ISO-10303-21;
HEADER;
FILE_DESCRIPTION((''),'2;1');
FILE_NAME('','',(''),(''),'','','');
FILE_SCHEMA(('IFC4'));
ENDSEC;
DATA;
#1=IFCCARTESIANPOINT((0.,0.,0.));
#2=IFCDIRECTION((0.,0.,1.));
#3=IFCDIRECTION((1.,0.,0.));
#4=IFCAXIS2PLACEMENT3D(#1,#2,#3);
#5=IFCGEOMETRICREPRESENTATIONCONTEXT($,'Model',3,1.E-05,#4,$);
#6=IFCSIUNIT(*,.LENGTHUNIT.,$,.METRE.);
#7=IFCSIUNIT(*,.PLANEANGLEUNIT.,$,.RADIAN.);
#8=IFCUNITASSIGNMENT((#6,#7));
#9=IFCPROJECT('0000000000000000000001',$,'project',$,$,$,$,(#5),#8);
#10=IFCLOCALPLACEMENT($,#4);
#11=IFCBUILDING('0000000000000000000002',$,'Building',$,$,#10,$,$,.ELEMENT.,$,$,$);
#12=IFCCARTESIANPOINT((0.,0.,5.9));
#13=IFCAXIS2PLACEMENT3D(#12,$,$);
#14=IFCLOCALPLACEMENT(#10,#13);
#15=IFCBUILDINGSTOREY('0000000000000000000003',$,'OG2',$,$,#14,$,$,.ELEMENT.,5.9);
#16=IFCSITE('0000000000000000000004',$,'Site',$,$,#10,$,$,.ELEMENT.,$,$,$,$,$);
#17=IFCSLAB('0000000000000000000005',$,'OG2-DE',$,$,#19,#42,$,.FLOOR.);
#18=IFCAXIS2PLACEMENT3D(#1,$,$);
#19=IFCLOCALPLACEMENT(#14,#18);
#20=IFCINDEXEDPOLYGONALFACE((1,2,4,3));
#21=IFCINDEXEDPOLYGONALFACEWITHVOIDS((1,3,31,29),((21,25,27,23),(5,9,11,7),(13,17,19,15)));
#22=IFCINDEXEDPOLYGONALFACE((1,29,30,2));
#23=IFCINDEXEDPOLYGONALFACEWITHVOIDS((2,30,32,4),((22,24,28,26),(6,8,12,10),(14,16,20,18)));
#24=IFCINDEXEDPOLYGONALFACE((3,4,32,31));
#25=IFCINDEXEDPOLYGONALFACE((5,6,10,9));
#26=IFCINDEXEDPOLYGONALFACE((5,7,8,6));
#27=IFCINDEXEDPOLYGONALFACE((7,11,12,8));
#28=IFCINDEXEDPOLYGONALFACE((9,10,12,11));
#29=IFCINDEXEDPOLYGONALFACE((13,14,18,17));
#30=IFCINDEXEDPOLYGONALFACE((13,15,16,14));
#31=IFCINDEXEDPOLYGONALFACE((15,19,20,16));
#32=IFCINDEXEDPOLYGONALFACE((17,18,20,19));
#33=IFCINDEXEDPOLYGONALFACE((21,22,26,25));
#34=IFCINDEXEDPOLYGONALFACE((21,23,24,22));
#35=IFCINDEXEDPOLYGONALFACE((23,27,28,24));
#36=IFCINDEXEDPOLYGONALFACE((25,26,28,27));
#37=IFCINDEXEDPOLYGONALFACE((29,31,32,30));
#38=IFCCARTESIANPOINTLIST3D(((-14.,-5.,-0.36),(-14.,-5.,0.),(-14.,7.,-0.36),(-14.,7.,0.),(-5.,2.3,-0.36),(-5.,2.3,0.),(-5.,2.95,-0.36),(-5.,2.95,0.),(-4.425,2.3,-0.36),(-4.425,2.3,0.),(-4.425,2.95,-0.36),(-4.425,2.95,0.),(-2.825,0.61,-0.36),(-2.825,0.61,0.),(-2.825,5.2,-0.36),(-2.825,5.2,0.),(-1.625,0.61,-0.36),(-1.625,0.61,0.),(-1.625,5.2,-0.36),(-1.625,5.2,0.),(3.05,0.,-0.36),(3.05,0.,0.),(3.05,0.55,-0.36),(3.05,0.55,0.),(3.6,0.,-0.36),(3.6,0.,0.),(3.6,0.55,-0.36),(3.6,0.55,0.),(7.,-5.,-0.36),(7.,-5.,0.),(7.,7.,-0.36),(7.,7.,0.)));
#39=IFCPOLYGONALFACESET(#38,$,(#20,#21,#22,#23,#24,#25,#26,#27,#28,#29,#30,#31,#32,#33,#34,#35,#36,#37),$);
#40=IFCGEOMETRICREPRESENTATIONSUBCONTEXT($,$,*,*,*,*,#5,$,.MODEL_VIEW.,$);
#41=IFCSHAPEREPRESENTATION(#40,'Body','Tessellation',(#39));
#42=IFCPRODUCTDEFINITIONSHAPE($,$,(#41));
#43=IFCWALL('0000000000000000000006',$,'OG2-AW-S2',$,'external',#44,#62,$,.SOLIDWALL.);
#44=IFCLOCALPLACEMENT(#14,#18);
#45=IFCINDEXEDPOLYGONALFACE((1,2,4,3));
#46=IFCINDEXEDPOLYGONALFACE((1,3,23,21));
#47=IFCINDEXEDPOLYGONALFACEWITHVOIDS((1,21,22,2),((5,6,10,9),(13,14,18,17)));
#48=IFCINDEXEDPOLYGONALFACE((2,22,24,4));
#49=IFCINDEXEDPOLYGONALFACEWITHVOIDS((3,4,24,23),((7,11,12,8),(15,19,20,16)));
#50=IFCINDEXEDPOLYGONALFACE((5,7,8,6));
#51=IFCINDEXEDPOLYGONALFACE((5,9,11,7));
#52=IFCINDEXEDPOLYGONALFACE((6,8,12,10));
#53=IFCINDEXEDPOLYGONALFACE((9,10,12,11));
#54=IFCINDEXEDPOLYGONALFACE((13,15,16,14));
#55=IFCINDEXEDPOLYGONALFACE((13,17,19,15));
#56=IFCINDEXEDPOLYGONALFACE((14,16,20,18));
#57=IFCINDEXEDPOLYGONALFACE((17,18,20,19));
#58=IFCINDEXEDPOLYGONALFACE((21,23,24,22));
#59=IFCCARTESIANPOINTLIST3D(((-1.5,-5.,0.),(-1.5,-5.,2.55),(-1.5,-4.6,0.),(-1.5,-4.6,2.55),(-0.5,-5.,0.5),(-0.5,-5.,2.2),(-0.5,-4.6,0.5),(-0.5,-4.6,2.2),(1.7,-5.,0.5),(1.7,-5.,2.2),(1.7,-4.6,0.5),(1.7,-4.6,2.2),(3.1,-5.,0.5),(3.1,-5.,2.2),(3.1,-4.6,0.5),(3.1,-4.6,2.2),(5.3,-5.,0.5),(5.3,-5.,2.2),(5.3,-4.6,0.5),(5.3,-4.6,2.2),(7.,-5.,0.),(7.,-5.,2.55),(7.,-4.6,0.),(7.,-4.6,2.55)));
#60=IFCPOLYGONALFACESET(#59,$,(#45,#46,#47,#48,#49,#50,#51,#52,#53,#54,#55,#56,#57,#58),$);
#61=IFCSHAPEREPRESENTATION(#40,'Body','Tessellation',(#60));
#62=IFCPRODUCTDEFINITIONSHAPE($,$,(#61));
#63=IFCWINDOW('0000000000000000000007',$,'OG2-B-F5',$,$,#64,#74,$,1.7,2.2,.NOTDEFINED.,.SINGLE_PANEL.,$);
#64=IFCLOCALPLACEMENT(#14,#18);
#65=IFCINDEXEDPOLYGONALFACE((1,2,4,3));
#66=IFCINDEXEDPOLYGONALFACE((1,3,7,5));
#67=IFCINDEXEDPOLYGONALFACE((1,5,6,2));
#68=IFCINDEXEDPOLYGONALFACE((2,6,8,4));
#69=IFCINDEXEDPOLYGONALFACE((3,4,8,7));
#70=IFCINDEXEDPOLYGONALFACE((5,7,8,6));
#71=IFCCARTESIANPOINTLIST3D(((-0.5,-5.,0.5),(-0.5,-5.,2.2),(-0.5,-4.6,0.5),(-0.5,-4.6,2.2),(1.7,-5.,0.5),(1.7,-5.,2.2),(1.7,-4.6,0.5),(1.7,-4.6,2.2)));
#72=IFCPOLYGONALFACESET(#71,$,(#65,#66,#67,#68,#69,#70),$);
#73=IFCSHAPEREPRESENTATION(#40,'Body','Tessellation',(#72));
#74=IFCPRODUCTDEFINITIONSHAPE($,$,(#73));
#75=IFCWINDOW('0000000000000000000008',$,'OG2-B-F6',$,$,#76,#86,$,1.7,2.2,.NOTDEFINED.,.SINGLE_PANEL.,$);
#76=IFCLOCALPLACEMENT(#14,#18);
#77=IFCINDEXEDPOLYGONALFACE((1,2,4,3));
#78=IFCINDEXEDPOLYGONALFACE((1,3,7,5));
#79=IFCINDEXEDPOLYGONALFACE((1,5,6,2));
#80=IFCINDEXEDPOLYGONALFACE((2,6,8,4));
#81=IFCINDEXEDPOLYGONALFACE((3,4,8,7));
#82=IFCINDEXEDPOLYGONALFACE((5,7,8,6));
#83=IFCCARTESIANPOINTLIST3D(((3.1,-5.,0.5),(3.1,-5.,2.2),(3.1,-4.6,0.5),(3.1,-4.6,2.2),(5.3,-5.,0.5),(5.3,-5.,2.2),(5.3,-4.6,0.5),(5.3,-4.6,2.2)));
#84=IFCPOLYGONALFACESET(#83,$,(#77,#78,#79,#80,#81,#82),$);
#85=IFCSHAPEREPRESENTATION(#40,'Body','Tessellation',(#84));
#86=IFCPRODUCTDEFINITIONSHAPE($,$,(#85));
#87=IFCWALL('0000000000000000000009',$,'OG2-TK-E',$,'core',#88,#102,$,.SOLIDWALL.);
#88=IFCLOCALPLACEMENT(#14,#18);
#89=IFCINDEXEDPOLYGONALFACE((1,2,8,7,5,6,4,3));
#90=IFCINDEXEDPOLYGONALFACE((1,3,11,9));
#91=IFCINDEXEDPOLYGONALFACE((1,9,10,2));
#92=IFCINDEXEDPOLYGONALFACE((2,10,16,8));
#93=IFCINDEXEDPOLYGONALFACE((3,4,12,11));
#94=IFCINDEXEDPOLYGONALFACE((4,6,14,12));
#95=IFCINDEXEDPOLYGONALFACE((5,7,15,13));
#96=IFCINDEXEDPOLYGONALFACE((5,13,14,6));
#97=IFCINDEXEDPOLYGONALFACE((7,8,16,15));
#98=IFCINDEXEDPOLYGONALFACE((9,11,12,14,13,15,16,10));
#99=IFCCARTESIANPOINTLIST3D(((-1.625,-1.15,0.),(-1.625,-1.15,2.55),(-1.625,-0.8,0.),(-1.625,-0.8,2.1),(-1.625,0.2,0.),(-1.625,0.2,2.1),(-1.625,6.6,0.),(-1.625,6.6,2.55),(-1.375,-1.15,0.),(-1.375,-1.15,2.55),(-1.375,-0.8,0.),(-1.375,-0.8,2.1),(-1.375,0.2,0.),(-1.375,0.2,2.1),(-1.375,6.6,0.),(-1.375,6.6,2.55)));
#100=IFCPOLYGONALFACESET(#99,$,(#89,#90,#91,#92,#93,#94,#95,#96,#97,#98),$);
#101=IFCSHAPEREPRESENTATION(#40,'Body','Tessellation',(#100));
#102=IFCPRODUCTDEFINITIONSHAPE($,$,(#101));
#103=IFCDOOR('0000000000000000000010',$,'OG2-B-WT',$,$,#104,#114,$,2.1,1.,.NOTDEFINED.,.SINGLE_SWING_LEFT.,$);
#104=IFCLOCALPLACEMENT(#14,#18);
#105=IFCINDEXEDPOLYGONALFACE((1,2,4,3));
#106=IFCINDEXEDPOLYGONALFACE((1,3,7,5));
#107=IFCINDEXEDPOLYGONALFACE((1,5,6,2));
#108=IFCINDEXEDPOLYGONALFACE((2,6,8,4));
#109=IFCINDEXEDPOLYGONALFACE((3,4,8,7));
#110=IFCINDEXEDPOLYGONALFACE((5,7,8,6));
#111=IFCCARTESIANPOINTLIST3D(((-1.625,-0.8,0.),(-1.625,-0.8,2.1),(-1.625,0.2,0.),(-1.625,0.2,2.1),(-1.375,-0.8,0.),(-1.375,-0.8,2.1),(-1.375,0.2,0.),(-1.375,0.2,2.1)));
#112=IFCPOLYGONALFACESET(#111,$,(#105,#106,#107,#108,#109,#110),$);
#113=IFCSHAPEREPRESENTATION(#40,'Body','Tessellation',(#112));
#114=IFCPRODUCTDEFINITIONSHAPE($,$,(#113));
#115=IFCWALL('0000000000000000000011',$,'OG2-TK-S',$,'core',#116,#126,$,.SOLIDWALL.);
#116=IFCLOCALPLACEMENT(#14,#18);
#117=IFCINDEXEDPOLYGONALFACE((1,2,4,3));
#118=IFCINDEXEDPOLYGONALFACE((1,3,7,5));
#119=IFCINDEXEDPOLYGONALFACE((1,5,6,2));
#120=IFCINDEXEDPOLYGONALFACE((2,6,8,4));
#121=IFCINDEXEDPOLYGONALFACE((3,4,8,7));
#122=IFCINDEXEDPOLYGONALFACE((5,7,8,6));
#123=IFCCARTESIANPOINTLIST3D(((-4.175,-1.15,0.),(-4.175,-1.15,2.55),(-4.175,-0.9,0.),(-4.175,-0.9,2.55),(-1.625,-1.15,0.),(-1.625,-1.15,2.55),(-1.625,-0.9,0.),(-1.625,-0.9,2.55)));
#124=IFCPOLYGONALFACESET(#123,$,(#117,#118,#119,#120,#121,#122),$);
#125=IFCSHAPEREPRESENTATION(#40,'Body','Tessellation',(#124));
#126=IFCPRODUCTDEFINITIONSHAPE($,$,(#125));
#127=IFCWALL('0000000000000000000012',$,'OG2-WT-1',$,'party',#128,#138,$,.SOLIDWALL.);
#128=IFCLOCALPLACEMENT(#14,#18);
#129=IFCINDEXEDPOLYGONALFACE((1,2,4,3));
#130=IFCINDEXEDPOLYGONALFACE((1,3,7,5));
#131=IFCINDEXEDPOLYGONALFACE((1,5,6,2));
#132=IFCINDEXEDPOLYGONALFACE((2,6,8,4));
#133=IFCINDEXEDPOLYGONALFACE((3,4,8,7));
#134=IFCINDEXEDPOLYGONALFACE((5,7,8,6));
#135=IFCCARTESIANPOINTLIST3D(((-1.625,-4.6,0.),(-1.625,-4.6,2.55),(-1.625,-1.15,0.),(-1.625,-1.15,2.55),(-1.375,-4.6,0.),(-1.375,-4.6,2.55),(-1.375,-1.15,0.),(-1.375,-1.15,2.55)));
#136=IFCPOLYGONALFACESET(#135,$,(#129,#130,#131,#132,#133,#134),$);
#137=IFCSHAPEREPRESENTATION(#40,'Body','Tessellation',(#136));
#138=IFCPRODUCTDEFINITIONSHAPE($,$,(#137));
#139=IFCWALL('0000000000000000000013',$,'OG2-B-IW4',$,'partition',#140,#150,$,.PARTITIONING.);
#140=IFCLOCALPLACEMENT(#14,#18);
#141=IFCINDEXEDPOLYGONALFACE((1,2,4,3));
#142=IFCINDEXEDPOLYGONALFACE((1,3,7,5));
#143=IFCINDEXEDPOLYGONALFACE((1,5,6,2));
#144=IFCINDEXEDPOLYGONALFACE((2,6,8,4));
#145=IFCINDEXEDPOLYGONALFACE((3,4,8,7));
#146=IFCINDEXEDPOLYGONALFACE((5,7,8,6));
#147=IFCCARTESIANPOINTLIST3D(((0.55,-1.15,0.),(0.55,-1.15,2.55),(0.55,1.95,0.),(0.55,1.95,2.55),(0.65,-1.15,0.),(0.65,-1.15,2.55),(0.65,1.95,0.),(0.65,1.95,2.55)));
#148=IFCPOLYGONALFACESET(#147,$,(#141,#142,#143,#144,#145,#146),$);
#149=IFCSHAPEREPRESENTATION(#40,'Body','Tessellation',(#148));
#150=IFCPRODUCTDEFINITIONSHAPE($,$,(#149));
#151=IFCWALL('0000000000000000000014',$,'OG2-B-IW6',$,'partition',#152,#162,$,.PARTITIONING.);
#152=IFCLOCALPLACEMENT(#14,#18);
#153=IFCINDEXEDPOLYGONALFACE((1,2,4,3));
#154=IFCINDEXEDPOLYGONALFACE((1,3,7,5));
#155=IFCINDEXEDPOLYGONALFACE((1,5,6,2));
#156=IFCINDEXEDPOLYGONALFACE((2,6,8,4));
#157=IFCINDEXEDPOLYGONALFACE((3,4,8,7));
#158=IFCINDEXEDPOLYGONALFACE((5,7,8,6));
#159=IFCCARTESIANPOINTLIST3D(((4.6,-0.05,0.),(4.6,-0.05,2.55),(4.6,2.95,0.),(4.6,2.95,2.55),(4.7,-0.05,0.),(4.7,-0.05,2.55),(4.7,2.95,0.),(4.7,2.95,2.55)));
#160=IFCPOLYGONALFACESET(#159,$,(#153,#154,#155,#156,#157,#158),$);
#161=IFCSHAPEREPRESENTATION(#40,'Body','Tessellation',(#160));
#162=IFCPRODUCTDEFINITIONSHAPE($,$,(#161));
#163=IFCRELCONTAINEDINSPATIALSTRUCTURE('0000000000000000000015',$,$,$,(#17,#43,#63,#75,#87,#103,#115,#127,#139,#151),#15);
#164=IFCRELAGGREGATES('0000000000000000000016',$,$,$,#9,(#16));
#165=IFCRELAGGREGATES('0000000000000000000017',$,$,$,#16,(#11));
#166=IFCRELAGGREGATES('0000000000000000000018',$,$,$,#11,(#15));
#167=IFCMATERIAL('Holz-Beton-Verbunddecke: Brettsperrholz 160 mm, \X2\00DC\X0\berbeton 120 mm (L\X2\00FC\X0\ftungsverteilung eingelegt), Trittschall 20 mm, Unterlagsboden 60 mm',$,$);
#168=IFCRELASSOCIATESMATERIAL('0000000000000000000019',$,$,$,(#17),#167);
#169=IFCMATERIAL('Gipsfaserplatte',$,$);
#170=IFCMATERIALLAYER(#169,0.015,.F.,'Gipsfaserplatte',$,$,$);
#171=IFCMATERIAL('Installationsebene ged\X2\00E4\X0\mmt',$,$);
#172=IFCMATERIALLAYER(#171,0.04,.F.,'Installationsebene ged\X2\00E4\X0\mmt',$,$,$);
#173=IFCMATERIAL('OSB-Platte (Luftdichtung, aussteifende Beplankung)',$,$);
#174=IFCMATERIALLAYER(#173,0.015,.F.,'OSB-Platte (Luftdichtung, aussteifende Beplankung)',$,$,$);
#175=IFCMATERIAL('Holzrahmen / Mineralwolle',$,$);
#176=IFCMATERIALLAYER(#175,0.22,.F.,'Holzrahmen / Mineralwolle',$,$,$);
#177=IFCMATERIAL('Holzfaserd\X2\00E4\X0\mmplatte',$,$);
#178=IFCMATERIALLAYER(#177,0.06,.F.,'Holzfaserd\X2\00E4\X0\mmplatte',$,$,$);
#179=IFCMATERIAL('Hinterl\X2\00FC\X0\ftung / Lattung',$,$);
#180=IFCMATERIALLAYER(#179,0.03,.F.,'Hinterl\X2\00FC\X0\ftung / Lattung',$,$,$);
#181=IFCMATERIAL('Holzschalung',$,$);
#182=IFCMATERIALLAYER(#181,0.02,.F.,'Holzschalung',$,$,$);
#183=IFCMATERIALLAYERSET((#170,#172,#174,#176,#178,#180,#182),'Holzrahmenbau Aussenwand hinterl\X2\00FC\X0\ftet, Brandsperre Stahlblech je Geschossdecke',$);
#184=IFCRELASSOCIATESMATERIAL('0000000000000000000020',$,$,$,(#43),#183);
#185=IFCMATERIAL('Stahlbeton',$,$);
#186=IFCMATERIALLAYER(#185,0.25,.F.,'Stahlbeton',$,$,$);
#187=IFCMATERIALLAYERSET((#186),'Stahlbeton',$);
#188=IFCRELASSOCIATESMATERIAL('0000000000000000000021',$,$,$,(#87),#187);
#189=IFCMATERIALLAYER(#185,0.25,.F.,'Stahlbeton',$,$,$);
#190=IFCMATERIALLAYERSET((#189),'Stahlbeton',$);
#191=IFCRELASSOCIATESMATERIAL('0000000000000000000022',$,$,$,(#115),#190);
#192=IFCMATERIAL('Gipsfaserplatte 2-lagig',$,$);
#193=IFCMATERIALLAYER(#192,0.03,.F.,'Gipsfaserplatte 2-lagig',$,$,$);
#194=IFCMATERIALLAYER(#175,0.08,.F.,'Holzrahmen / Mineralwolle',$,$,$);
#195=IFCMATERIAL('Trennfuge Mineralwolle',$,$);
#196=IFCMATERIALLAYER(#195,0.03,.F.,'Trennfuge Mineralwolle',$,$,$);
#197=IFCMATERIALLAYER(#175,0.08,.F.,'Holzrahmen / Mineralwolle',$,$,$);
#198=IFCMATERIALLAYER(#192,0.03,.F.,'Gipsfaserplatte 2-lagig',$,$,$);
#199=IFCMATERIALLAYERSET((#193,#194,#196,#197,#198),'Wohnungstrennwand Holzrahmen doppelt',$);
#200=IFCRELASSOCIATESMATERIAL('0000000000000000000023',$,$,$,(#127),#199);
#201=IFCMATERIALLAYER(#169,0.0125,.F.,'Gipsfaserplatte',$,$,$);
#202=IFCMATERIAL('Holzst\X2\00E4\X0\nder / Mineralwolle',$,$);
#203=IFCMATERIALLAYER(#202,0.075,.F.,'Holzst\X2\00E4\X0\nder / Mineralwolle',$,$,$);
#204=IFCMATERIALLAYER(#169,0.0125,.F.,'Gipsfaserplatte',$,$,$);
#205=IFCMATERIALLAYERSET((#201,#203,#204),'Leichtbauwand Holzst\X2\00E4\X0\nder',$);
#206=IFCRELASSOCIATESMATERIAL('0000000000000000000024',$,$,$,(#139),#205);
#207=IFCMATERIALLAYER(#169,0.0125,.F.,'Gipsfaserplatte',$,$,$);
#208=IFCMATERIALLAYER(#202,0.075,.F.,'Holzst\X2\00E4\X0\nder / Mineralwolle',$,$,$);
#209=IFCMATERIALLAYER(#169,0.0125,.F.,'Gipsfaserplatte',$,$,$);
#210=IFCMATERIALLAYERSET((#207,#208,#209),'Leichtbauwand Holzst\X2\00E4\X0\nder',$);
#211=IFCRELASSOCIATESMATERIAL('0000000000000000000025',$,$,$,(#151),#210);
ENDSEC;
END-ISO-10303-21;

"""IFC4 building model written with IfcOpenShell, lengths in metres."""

from ifc_helpers import new_model, si_unit, frame, frame_2d, origin, origin_with_axes, origin_2d, place, context, subcontext, project, spatial, polyline, rectangle, outline, extrude, material, layer, layer_set, element, fill, save


model = new_model("IFC4")

# Units and contexts
model_context = context("Model", 3, precision=1e-05, world=origin_with_axes())
sub_context = subcontext(model_context, None, None, "MODEL_VIEW")
ifc_project = project(units=[si_unit("LENGTHUNIT", "METRE"), si_unit("PLANEANGLEUNIT", "RADIAN")], contexts=[model_context])

# Site, building, storey
placement = place(None, origin_with_axes())
site = spatial("IfcSite", under=ifc_project, at=placement, Name="Site", CompositionType="ELEMENT")
building = spatial("IfcBuilding", under=site, at=placement, Name="Building", CompositionType="ELEMENT")
storey_placement = place(placement, frame((0.0, 0.0, 5.9)))
storey = spatial("IfcBuildingStorey", under=building, at=storey_placement, Name="OG2", CompositionType="ELEMENT", Elevation=5.9)

# Slab, openings
ifc_material_1 = material(Name="Holz-Beton-Verbunddecke: Brettsperrholz 160 mm, Überbeton 120 mm (Lüftungsverteilung eingelegt), Trittschall 20 mm, Unterlagsboden 60 mm")
slab_placement = place(storey_placement, frame((0.0, 0.0, -0.36)))
slab = element("IfcSlab", 1, at=slab_placement, inside=storey, material=ifc_material_1, Name="OG2-DE", PredefinedType="FLOOR", context=sub_context, shape_type="SweptSolid", body=[
    extrude(outline(polyline([(-14.0, -5.0), (7.0, -5.0), (7.0, 7.0), (-14.0, 7.0), (-14.0, -5.0)])), origin(), (0.0, 0.0, 1.0), 0.36),
])
opening_1_placement = place(slab_placement, frame((-2.225, 2.905, 0.0)))
element("IfcOpeningElement", 2, at=opening_1_placement, cuts=slab, PredefinedType="OPENING", context=sub_context, shape_type="SweptSolid", body=[
    extrude(rectangle(XDim=1.2, YDim=4.59, at=origin_2d()), origin(), (0.0, 0.0, 1.0), 0.46),
])
opening_2_placement = place(slab_placement, frame((-4.7125, 2.625, 0.0)))
element("IfcOpeningElement", 3, at=opening_2_placement, cuts=slab, PredefinedType="OPENING", context=sub_context, shape_type="SweptSolid", body=[
    extrude(rectangle(XDim=0.575, YDim=0.65, at=origin_2d()), origin(), (0.0, 0.0, 1.0), 0.46),
])
opening_3_placement = place(slab_placement, frame((3.325, 0.275, 0.0)))
element("IfcOpeningElement", 4, at=opening_3_placement, cuts=slab, PredefinedType="OPENING", context=sub_context, shape_type="SweptSolid", body=[
    extrude(rectangle(XDim=0.55, YDim=0.55, at=origin_2d()), origin(), (0.0, 0.0, 1.0), 0.46),
])

# Wall, openings, windows
ifc_material_2 = material(Name="Gipsfaserplatte")
ifc_layer_1 = layer(ifc_material_2, 0.015, ventilated=False, Name="Gipsfaserplatte")
ifc_material_3 = material(Name="Installationsebene gedämmt")
ifc_layer_2 = layer(ifc_material_3, 0.04, ventilated=False, Name="Installationsebene gedämmt")
ifc_material_4 = material(Name="OSB-Platte (Luftdichtung, aussteifende Beplankung)")
ifc_layer_3 = layer(ifc_material_4, 0.015, ventilated=False, Name="OSB-Platte (Luftdichtung, aussteifende Beplankung)")
ifc_material_5 = material(Name="Holzrahmen / Mineralwolle")
ifc_layer_4 = layer(ifc_material_5, 0.22, ventilated=False, Name="Holzrahmen / Mineralwolle")
ifc_material_6 = material(Name="Holzfaserdämmplatte")
ifc_layer_5 = layer(ifc_material_6, 0.06, ventilated=False, Name="Holzfaserdämmplatte")
ifc_material_7 = material(Name="Hinterlüftung / Lattung")
ifc_layer_6 = layer(ifc_material_7, 0.03, ventilated=False, Name="Hinterlüftung / Lattung")
ifc_material_8 = material(Name="Holzschalung")
ifc_layer_7 = layer(ifc_material_8, 0.02, ventilated=False, Name="Holzschalung")
ifc_layer_set_1 = layer_set([ifc_layer_1, ifc_layer_2, ifc_layer_3, ifc_layer_4, ifc_layer_5, ifc_layer_6, ifc_layer_7], Name="Holzrahmenbau Aussenwand hinterlüftet, Brandsperre Stahlblech je Geschossdecke")
wall_1_placement = place(storey_placement, frame((7.0, -4.8, 0.0), z_axis=(0.0, 0.0, 1.0), x_axis=(-1.0, 0.0, 0.0)))
wall_1 = element("IfcWall", 5, at=wall_1_placement, inside=storey, material=ifc_layer_set_1, Name="OG2-AW-S2", ObjectType="external", PredefinedType="SOLIDWALL", context=sub_context, shape_type="SweptSolid", body=[
    extrude(rectangle(XDim=8.5, YDim=0.4, at=frame_2d((4.25, 0.0))), origin(), (0.0, 0.0, 1.0), 2.55),
])
opening_4_placement = place(wall_1_placement, frame((6.4, 0.25, 0.5), z_axis=(0.0, -1.0, 0.0), x_axis=(1.0, 0.0, 0.0)))
opening_4 = element("IfcOpeningElement", 6, at=opening_4_placement, cuts=wall_1, PredefinedType="OPENING", context=sub_context, shape_type="SweptSolid", body=[
    extrude(rectangle(XDim=2.2, YDim=1.7, at=frame_2d((0.0, 0.85))), origin(), (0.0, 0.0, 1.0), 0.5),
])
opening_5_placement = place(wall_1_placement, frame((2.8, 0.25, 0.5), z_axis=(0.0, -1.0, 0.0), x_axis=(1.0, 0.0, 0.0)))
opening_5 = element("IfcOpeningElement", 7, at=opening_5_placement, cuts=wall_1, PredefinedType="OPENING", context=sub_context, shape_type="SweptSolid", body=[
    extrude(rectangle(XDim=2.2, YDim=1.7, at=frame_2d((0.0, 0.85))), origin(), (0.0, 0.0, 1.0), 0.5),
])
window_1_placement = place(wall_1_placement, frame((6.4, 0.2, 0.5), z_axis=(0.0, -1.0, 0.0), x_axis=(1.0, 0.0, 0.0)))
window_1 = element("IfcWindow", 8, at=window_1_placement, inside=storey, Name="OG2-B-F5", OverallHeight=1.7, OverallWidth=2.2, PartitioningType="SINGLE_PANEL", PredefinedType="NOTDEFINED", context=sub_context, shape_type="SweptSolid", body=[
    extrude(rectangle(XDim=2.2, YDim=1.7, at=frame_2d((0.0, 0.85))), origin(), (0.0, 0.0, 1.0), 0.4),
])
fill(opening_4, window_1)
window_2_placement = place(wall_1_placement, frame((2.8, 0.2, 0.5), z_axis=(0.0, -1.0, 0.0), x_axis=(1.0, 0.0, 0.0)))
window_2 = element("IfcWindow", 9, at=window_2_placement, inside=storey, Name="OG2-B-F6", OverallHeight=1.7, OverallWidth=2.2, PartitioningType="SINGLE_PANEL", PredefinedType="NOTDEFINED", context=sub_context, shape_type="SweptSolid", body=[
    extrude(rectangle(XDim=2.2, YDim=1.7, at=frame_2d((0.0, 0.85))), origin(), (0.0, 0.0, 1.0), 0.4),
])
fill(opening_5, window_2)

# Wall, opening, door
ifc_material_9 = material(Name="Stahlbeton")
ifc_layer_8 = layer(ifc_material_9, 0.25, ventilated=False, Name="Stahlbeton")
ifc_layer_set_2 = layer_set([ifc_layer_8], Name="Stahlbeton")
wall_2_placement = place(storey_placement, frame((-1.5, -1.15, 0.0), z_axis=(0.0, 0.0, 1.0), x_axis=(0.0, 1.0, 0.0)))
wall_2 = element("IfcWall", 10, at=wall_2_placement, inside=storey, material=ifc_layer_set_2, Name="OG2-TK-E", ObjectType="core", PredefinedType="SOLIDWALL", context=sub_context, shape_type="SweptSolid", body=[
    extrude(rectangle(XDim=7.75, YDim=0.25, at=frame_2d((3.875, 0.0))), origin(), (0.0, 0.0, 1.0), 2.55),
])
opening_6_placement = place(wall_2_placement, frame((0.85, 0.175, 0.0), z_axis=(0.0, -1.0, 0.0), x_axis=(1.0, 0.0, 0.0)))
opening_6 = element("IfcOpeningElement", 11, at=opening_6_placement, cuts=wall_2, PredefinedType="OPENING", context=sub_context, shape_type="SweptSolid", body=[
    extrude(rectangle(XDim=1.0, YDim=2.1, at=frame_2d((0.0, 1.05))), origin(), (0.0, 0.0, 1.0), 0.35),
])
door_1_placement = place(wall_2_placement, frame((0.85, 0.125, 0.0), z_axis=(0.0, -1.0, 0.0), x_axis=(1.0, 0.0, 0.0)))
door_1 = element("IfcDoor", 12, at=door_1_placement, inside=storey, Name="OG2-B-WT", OperationType="SINGLE_SWING_LEFT", OverallHeight=2.1, OverallWidth=1.0, PredefinedType="NOTDEFINED", context=sub_context, shape_type="SweptSolid", body=[
    extrude(rectangle(XDim=1.0, YDim=2.1, at=frame_2d((0.0, 1.05))), origin(), (0.0, 0.0, 1.0), 0.25),
])
fill(opening_6, door_1)

# Walls
ifc_layer_9 = layer(ifc_material_9, 0.25, ventilated=False, Name="Stahlbeton")
ifc_layer_set_3 = layer_set([ifc_layer_9], Name="Stahlbeton")
wall_3_placement = place(storey_placement, frame((-4.175, -1.025, 0.0), z_axis=(0.0, 0.0, 1.0), x_axis=(1.0, 0.0, 0.0)))
element("IfcWall", 13, at=wall_3_placement, inside=storey, material=ifc_layer_set_3, Name="OG2-TK-S", ObjectType="core", PredefinedType="SOLIDWALL", context=sub_context, shape_type="SweptSolid", body=[
    extrude(rectangle(XDim=2.55, YDim=0.25, at=frame_2d((1.275, 0.0))), origin(), (0.0, 0.0, 1.0), 2.55),
])
ifc_material_10 = material(Name="Gipsfaserplatte 2-lagig")
ifc_layer_10 = layer(ifc_material_10, 0.03, ventilated=False, Name="Gipsfaserplatte 2-lagig")
ifc_layer_11 = layer(ifc_material_5, 0.08, ventilated=False, Name="Holzrahmen / Mineralwolle")
ifc_material_11 = material(Name="Trennfuge Mineralwolle")
ifc_layer_12 = layer(ifc_material_11, 0.03, ventilated=False, Name="Trennfuge Mineralwolle")
ifc_layer_13 = layer(ifc_material_5, 0.08, ventilated=False, Name="Holzrahmen / Mineralwolle")
ifc_layer_14 = layer(ifc_material_10, 0.03, ventilated=False, Name="Gipsfaserplatte 2-lagig")
ifc_layer_set_4 = layer_set([ifc_layer_10, ifc_layer_11, ifc_layer_12, ifc_layer_13, ifc_layer_14], Name="Wohnungstrennwand Holzrahmen doppelt")
wall_4_placement = place(storey_placement, frame((-1.5, -1.15, 0.0), z_axis=(0.0, 0.0, 1.0), x_axis=(0.0, -1.0, 0.0)))
element("IfcWall", 14, at=wall_4_placement, inside=storey, material=ifc_layer_set_4, Name="OG2-WT-1", ObjectType="party", PredefinedType="SOLIDWALL", context=sub_context, shape_type="SweptSolid", body=[
    extrude(rectangle(XDim=3.45, YDim=0.25, at=frame_2d((1.725, 0.0))), origin(), (0.0, 0.0, 1.0), 2.55),
])
ifc_layer_15 = layer(ifc_material_2, 0.0125, ventilated=False, Name="Gipsfaserplatte")
ifc_material_12 = material(Name="Holzständer / Mineralwolle")
ifc_layer_16 = layer(ifc_material_12, 0.075, ventilated=False, Name="Holzständer / Mineralwolle")
ifc_layer_17 = layer(ifc_material_2, 0.0125, ventilated=False, Name="Gipsfaserplatte")
ifc_layer_set_5 = layer_set([ifc_layer_15, ifc_layer_16, ifc_layer_17], Name="Leichtbauwand Holzständer")
wall_5_placement = place(storey_placement, frame((0.6, -1.15, 0.0), z_axis=(0.0, 0.0, 1.0), x_axis=(0.0, 1.0, 0.0)))
element("IfcWall", 15, at=wall_5_placement, inside=storey, material=ifc_layer_set_5, Name="OG2-B-IW4", ObjectType="partition", PredefinedType="PARTITIONING", context=sub_context, shape_type="SweptSolid", body=[
    extrude(rectangle(XDim=3.1, YDim=0.1, at=frame_2d((1.55, 0.0))), origin(), (0.0, 0.0, 1.0), 2.55),
])
ifc_layer_18 = layer(ifc_material_2, 0.0125, ventilated=False, Name="Gipsfaserplatte")
ifc_layer_19 = layer(ifc_material_12, 0.075, ventilated=False, Name="Holzständer / Mineralwolle")
ifc_layer_20 = layer(ifc_material_2, 0.0125, ventilated=False, Name="Gipsfaserplatte")
ifc_layer_set_6 = layer_set([ifc_layer_18, ifc_layer_19, ifc_layer_20], Name="Leichtbauwand Holzständer")
wall_6_placement = place(storey_placement, frame((4.65, -0.05, 0.0), z_axis=(0.0, 0.0, 1.0), x_axis=(0.0, 1.0, 0.0)))
element("IfcWall", 16, at=wall_6_placement, inside=storey, material=ifc_layer_set_6, Name="OG2-B-IW6", ObjectType="partition", PredefinedType="PARTITIONING", context=sub_context, shape_type="SweptSolid", body=[
    extrude(rectangle(XDim=3.0, YDim=0.1, at=frame_2d((1.5, 0.0))), origin(), (0.0, 0.0, 1.0), 2.55),
])

save(model, "model.ifc")
